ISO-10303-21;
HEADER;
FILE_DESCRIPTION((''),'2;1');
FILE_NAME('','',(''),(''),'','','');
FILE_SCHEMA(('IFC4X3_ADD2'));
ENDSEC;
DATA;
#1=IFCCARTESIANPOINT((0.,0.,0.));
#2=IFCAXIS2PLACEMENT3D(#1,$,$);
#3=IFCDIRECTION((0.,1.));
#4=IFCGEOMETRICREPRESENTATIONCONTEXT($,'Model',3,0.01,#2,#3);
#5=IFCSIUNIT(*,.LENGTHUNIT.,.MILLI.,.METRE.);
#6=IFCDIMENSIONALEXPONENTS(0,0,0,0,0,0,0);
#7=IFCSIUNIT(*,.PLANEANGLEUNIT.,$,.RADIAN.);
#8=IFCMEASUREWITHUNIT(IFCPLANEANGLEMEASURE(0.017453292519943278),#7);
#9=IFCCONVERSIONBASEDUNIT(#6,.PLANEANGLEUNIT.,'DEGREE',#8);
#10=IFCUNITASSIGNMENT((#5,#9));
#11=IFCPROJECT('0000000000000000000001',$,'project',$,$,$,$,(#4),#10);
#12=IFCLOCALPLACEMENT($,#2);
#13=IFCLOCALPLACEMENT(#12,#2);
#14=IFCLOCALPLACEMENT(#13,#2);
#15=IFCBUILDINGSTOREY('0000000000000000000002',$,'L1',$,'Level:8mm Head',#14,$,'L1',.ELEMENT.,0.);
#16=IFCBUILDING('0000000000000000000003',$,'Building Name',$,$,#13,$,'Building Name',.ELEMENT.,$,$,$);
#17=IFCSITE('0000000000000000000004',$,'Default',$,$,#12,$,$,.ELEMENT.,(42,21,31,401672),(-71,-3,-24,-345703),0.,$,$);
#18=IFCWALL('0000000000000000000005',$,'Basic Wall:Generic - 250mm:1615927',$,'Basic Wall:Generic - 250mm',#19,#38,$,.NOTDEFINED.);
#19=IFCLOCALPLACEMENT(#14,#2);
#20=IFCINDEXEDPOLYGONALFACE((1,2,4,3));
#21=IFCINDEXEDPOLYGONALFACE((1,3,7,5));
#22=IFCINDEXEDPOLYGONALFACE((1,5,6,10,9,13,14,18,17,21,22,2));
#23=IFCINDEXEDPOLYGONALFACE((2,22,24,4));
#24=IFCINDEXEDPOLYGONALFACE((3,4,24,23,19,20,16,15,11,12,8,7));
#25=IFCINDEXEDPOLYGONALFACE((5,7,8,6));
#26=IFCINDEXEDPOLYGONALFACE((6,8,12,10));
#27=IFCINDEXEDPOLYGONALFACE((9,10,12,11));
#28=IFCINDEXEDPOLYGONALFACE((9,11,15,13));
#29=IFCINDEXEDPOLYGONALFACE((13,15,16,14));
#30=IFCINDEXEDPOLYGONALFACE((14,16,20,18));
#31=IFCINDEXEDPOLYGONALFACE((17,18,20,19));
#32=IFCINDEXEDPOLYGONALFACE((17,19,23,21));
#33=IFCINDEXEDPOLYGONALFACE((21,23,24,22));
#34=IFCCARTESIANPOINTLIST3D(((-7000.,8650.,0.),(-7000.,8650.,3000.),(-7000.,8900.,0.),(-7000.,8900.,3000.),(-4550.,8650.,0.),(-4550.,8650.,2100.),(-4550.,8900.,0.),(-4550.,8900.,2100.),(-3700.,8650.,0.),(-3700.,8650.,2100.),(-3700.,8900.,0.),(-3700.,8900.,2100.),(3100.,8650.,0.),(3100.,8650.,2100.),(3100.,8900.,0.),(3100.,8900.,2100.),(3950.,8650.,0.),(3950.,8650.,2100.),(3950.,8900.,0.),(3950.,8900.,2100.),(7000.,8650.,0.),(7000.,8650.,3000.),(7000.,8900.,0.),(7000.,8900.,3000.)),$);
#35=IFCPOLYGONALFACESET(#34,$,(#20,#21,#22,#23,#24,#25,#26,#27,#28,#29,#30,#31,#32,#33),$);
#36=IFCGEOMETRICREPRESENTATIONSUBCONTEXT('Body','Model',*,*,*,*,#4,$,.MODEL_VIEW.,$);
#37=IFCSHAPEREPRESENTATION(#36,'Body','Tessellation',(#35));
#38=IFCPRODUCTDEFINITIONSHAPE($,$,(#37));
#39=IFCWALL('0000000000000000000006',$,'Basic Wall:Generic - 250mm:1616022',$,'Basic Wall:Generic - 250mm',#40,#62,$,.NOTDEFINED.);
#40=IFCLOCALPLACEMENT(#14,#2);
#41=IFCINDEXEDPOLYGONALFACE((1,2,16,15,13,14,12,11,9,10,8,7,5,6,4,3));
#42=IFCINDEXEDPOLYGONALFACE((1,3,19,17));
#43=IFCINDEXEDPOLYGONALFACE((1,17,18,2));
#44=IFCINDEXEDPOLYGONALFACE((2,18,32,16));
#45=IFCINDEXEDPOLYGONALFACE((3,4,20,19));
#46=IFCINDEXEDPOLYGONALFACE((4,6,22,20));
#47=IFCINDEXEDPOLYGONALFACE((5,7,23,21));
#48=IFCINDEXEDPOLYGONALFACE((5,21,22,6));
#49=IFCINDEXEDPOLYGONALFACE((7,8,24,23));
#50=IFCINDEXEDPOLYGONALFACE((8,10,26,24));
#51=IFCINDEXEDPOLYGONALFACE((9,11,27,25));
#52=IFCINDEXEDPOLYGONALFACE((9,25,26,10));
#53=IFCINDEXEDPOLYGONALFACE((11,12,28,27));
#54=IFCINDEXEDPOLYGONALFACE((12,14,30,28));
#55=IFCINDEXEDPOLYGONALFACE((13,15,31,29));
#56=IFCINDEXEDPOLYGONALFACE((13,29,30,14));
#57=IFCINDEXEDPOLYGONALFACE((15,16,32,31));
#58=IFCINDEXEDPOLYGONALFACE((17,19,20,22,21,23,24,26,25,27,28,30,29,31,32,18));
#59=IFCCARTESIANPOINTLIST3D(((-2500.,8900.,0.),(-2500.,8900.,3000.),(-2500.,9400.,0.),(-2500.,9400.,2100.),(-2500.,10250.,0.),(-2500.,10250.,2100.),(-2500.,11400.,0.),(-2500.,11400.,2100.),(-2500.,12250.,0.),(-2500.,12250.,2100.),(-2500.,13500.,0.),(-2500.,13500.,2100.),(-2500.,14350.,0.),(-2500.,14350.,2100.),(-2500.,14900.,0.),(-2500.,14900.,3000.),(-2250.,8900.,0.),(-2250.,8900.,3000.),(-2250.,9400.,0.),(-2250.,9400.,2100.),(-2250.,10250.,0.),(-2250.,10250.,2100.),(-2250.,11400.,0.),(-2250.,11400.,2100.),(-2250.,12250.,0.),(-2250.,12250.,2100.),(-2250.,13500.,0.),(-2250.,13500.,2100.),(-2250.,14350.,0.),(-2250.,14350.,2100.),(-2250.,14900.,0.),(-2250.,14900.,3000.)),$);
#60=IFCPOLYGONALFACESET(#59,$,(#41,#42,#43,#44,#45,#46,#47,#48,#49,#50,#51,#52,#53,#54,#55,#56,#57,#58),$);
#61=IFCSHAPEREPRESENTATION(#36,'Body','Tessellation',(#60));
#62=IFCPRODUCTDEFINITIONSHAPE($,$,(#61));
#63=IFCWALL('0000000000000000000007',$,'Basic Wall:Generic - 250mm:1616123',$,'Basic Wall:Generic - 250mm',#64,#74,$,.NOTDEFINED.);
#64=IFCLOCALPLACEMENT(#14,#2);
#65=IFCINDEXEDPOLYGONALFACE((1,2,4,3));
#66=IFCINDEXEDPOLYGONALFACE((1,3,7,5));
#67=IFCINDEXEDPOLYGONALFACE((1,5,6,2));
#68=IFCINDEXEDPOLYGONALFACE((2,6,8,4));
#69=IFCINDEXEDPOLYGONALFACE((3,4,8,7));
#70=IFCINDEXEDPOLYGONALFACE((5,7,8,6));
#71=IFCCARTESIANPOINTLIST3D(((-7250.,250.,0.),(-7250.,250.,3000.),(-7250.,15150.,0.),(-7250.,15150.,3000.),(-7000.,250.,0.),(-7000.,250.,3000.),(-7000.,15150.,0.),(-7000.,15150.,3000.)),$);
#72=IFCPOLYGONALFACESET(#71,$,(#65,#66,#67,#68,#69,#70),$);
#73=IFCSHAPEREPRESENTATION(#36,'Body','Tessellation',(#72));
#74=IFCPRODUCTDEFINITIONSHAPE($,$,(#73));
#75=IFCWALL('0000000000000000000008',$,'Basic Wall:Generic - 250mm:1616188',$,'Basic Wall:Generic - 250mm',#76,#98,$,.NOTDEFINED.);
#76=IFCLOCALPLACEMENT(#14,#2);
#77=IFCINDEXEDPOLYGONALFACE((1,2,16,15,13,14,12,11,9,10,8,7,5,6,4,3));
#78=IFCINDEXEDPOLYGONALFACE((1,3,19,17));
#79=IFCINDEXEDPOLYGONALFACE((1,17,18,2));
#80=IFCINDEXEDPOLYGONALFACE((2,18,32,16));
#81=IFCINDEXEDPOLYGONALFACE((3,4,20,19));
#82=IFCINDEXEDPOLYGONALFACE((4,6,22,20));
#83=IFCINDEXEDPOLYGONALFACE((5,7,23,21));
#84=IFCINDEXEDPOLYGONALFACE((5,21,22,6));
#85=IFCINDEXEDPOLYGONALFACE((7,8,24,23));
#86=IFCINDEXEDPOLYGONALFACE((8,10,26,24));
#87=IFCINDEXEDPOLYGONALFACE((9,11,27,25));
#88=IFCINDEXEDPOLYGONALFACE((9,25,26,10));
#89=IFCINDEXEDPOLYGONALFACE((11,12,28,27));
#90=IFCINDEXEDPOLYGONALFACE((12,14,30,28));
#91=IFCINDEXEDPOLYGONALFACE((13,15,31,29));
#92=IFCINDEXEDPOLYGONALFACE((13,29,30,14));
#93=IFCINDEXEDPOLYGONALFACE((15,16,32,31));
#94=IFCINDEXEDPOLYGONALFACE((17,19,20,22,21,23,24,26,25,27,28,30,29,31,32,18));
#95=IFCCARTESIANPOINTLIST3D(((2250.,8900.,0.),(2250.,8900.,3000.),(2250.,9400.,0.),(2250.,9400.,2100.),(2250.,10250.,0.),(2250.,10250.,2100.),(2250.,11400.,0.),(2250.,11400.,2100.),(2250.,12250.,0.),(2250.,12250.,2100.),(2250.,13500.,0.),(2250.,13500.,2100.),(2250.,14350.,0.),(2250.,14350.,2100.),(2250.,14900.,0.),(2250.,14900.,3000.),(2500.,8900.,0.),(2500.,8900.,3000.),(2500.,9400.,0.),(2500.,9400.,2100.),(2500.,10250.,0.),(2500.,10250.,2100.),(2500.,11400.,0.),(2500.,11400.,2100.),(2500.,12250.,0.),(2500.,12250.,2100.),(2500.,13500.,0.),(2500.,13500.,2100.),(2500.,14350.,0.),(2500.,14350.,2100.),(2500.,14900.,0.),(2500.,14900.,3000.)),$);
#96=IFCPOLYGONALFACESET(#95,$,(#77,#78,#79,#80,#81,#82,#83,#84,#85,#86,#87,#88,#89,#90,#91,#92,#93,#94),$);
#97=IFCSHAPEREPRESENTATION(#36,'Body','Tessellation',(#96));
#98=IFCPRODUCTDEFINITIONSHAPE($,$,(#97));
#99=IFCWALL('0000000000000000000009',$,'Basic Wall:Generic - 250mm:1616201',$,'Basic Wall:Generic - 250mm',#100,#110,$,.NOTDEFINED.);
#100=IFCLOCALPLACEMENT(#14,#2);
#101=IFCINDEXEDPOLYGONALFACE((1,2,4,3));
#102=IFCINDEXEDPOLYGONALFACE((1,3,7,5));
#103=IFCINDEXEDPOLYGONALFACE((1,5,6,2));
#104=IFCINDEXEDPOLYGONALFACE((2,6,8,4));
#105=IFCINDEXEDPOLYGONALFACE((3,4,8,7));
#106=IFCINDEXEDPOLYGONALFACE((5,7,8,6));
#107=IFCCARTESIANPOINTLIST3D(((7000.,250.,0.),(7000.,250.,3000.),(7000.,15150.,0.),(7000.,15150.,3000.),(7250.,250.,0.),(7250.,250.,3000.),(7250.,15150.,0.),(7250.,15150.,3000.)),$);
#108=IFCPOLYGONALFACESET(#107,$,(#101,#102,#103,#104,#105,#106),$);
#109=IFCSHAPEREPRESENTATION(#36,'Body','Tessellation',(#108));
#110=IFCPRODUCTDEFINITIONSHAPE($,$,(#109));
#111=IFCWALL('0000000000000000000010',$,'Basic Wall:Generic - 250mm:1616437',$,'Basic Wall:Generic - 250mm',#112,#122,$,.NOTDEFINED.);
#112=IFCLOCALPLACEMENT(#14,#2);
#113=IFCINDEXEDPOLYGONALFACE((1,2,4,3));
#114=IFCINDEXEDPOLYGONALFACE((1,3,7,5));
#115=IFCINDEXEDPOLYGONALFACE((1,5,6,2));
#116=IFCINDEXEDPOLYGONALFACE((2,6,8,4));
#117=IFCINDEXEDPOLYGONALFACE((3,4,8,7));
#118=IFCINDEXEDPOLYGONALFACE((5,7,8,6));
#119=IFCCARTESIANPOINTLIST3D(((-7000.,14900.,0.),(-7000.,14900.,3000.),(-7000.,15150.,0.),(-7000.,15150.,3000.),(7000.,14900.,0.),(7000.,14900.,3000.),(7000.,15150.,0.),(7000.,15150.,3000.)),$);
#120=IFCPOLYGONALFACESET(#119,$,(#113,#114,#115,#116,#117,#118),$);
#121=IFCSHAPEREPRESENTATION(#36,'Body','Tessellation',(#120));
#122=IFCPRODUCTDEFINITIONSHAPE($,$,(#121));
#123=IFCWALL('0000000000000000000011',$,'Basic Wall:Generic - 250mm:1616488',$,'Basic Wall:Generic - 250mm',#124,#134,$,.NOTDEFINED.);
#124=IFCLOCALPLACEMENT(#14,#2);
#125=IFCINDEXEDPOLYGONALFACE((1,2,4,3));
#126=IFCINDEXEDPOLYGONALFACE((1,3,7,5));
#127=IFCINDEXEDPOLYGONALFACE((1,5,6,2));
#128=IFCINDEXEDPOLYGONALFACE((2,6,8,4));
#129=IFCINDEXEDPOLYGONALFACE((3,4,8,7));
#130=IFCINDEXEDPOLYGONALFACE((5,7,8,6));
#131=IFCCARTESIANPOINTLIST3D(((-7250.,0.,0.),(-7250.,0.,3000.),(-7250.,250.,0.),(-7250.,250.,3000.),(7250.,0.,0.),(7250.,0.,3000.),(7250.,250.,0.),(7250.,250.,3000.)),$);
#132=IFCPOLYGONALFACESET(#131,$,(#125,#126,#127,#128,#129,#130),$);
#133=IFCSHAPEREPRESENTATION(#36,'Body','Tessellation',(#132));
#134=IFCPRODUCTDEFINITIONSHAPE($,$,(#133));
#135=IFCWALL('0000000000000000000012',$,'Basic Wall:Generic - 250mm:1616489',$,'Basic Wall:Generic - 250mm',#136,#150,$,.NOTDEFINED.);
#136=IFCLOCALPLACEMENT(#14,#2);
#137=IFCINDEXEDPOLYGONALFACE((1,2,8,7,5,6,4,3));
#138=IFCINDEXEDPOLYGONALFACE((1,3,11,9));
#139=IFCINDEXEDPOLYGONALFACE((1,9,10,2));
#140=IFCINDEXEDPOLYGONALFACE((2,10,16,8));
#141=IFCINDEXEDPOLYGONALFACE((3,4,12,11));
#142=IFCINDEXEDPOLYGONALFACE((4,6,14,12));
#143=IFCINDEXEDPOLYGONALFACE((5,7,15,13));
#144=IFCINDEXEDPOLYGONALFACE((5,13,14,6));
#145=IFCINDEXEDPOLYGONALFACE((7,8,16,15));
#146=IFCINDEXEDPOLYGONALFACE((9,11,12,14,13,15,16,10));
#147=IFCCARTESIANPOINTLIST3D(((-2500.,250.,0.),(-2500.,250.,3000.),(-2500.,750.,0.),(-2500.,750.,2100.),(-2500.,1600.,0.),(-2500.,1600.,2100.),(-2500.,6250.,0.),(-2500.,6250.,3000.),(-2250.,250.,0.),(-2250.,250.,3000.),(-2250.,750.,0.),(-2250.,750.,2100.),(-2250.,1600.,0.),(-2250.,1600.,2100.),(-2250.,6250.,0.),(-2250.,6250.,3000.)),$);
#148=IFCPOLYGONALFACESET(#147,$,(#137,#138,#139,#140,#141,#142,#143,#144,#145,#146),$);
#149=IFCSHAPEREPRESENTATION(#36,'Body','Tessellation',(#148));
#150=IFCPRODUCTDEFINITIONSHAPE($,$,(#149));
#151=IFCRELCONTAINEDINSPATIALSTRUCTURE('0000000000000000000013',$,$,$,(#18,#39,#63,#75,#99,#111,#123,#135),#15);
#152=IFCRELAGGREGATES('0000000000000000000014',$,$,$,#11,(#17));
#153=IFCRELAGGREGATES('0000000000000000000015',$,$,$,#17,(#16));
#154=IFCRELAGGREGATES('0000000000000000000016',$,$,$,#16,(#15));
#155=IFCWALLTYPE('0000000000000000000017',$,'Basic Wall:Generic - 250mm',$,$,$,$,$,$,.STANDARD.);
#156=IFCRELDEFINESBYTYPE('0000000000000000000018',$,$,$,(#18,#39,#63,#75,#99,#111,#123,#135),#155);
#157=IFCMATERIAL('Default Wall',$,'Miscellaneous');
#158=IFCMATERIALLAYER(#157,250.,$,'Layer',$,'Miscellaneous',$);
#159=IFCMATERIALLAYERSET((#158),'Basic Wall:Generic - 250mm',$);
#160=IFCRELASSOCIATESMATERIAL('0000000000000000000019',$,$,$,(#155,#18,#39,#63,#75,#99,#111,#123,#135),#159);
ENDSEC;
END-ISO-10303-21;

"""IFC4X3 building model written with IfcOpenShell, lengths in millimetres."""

from ifc_helpers import new_model, entity, si_unit, converted_unit, direction, frame, frame_2d, origin, place, context, subcontext, project, spatial, rectangle, extrude, material, layer, layer_set, type_object, element, save


model = new_model("IFC4X3")

# Units and contexts
model_context = context("Model", 3, precision=0.01, world=origin(), true_north=direction((0.0, 1.0)))
body_context = subcontext(model_context, "Body", "Model", "MODEL_VIEW")
ifc_project = project(units=[si_unit("LENGTHUNIT", "METRE", prefix="MILLI"), converted_unit("PLANEANGLEUNIT", "DEGREE", entity("IfcPlaneAngleMeasure", 0.017453292519943278), si_unit("PLANEANGLEUNIT", "RADIAN"), dimensions=[0, 0, 0, 0, 0, 0, 0])], contexts=[model_context])

# Site, building, storey
site_placement = place(None, origin())
site = spatial("IfcSite", under=ifc_project, at=site_placement, Name="Default", CompositionType="ELEMENT", RefLatitude=(42, 21, 31, 401672), RefLongitude=(-71, -3, -24, -345703), RefElevation=0.0)
building_placement = place(site_placement, origin())
building = spatial("IfcBuilding", under=site, at=building_placement, Name="Building Name", LongName="Building Name", CompositionType="ELEMENT")
storey_placement = place(building_placement, origin())
storey = spatial("IfcBuildingStorey", under=building, at=storey_placement, Name="L1", ObjectType="Level:8mm Head", LongName="L1", CompositionType="ELEMENT", Elevation=0.0)

# Walls, openings
ifc_material = material(Name="Default Wall", Category="Miscellaneous")
ifc_layer_1 = layer(ifc_material, 250.0, Name="Layer", Category="Miscellaneous")
ifc_layer_set_1 = layer_set([ifc_layer_1], Name="Basic Wall:Generic - 250mm")
wall_type_1 = type_object("IfcWallType", Name="Basic Wall:Generic - 250mm", PredefinedType="STANDARD", material=ifc_layer_set_1)
wall_1_placement = place(storey_placement, frame((-7000.0, 8775.0, 0.0)))
wall_1 = element("IfcWall", 1, at=wall_1_placement, inside=storey, type_object=wall_type_1, material=ifc_layer_set_1, Name="Basic Wall:Generic - 250mm:1615927", ObjectType="Basic Wall:Generic - 250mm", PredefinedType="NOTDEFINED", context=body_context, shape_type="SweptSolid", body=[
    extrude(rectangle(XDim=14000.0, YDim=250.0, at=frame_2d((7000.0, 0.0), x_axis=(1.0, 0.0))), origin(), (0.0, 0.0, 1.0), 3000.0),
])
opening_1_placement = place(wall_1_placement, frame((2450.0, -125.0, 0.0)))
element("IfcOpeningElement", 2, at=opening_1_placement, cuts=wall_1, PredefinedType="OPENING", context=body_context, shape_type="SweptSolid", body=[
    extrude(rectangle(XDim=2100.0, YDim=850.0, at=frame_2d((1050.0, 425.0), x_axis=(1.0, 0.0))), frame((0.0, 0.0, 0.0), z_axis=(0.0, 1.0, 0.0), x_axis=(0.0, 0.0, 1.0)), (0.0, 0.0, 1.0), 250.0),
])
opening_2_placement = place(wall_1_placement, frame((10100.0, -125.0, 0.0)))
element("IfcOpeningElement", 3, at=opening_2_placement, cuts=wall_1, PredefinedType="OPENING", context=body_context, shape_type="SweptSolid", body=[
    extrude(rectangle(XDim=2100.0, YDim=850.0, at=frame_2d((1050.0, 425.0), x_axis=(1.0, 0.0))), frame((0.0, 0.0, 0.0), z_axis=(0.0, 1.0, 0.0), x_axis=(0.0, 0.0, 1.0)), (0.0, 0.0, 1.0), 250.0),
])
wall_2_placement = place(storey_placement, frame((-2375.0, 8900.0, 0.0), z_axis=(0.0, 0.0, 1.0), x_axis=(0.0, 1.0, 0.0)))
wall_2 = element("IfcWall", 4, at=wall_2_placement, inside=storey, type_object=wall_type_1, material=ifc_layer_set_1, Name="Basic Wall:Generic - 250mm:1616022", ObjectType="Basic Wall:Generic - 250mm", PredefinedType="NOTDEFINED", context=body_context, shape_type="SweptSolid", body=[
    extrude(rectangle(XDim=6000.0, YDim=250.0, at=frame_2d((3000.0, 0.0), x_axis=(1.0, 0.0))), origin(), (0.0, 0.0, 1.0), 3000.0),
])
opening_3_placement = place(wall_2_placement, frame((1350.0, 125.0, 0.0)))
element("IfcOpeningElement", 5, at=opening_3_placement, cuts=wall_2, PredefinedType="OPENING", context=body_context, shape_type="SweptSolid", body=[
    extrude(rectangle(XDim=2100.0, YDim=850.0, at=frame_2d((1050.0, 425.0), x_axis=(1.0, 0.0))), frame((0.0, 0.0, 0.0), z_axis=(0.0, -1.0, 0.0), x_axis=(0.0, 0.0, 1.0)), (0.0, 0.0, 1.0), 250.0),
])
opening_4_placement = place(wall_2_placement, frame((3350.0, 125.0, 0.0)))
element("IfcOpeningElement", 6, at=opening_4_placement, cuts=wall_2, PredefinedType="OPENING", context=body_context, shape_type="SweptSolid", body=[
    extrude(rectangle(XDim=2100.0, YDim=850.0, at=frame_2d((1050.0, 425.0), x_axis=(1.0, 0.0))), frame((0.0, 0.0, 0.0), z_axis=(0.0, -1.0, 0.0), x_axis=(0.0, 0.0, 1.0)), (0.0, 0.0, 1.0), 250.0),
])
opening_5_placement = place(wall_2_placement, frame((5450.0, 125.0, 0.0)))
element("IfcOpeningElement", 7, at=opening_5_placement, cuts=wall_2, PredefinedType="OPENING", context=body_context, shape_type="SweptSolid", body=[
    extrude(rectangle(XDim=2100.0, YDim=850.0, at=frame_2d((1050.0, 425.0), x_axis=(1.0, 0.0))), frame((0.0, 0.0, 0.0), z_axis=(0.0, -1.0, 0.0), x_axis=(0.0, 0.0, 1.0)), (0.0, 0.0, 1.0), 250.0),
])

# Wall
wall_3_placement = place(storey_placement, frame((-7125.0, 15150.0, 0.0), z_axis=(0.0, 0.0, 1.0), x_axis=(0.0, -1.0, 0.0)))
element("IfcWall", 8, at=wall_3_placement, inside=storey, type_object=wall_type_1, material=ifc_layer_set_1, Name="Basic Wall:Generic - 250mm:1616123", ObjectType="Basic Wall:Generic - 250mm", PredefinedType="NOTDEFINED", context=body_context, shape_type="SweptSolid", body=[
    extrude(rectangle(XDim=14900.0, YDim=250.0, at=frame_2d((7450.0, 0.0), x_axis=(-1.0, 0.0))), origin(), (0.0, 0.0, 1.0), 3000.0),
])

# Wall, openings
wall_4_placement = place(storey_placement, frame((2375.0, 8900.0, 0.0), z_axis=(0.0, 0.0, 1.0), x_axis=(0.0, 1.0, 0.0)))
wall_4 = element("IfcWall", 9, at=wall_4_placement, inside=storey, type_object=wall_type_1, material=ifc_layer_set_1, Name="Basic Wall:Generic - 250mm:1616188", ObjectType="Basic Wall:Generic - 250mm", PredefinedType="NOTDEFINED", context=body_context, shape_type="SweptSolid", body=[
    extrude(rectangle(XDim=6000.0, YDim=250.0, at=frame_2d((3000.0, 0.0), x_axis=(-1.0, 0.0))), origin(), (0.0, 0.0, 1.0), 3000.0),
])
opening_6_placement = place(wall_4_placement, frame((500.0, -125.0, 0.0)))
element("IfcOpeningElement", 10, at=opening_6_placement, cuts=wall_4, PredefinedType="OPENING", context=body_context, shape_type="SweptSolid", body=[
    extrude(rectangle(XDim=2100.0, YDim=850.0, at=frame_2d((1050.0, 425.0), x_axis=(1.0, 0.0))), frame((0.0, 0.0, 0.0), z_axis=(0.0, 1.0, 0.0), x_axis=(0.0, 0.0, 1.0)), (0.0, 0.0, 1.0), 250.0),
])
opening_7_placement = place(wall_4_placement, frame((2500.0, -125.0, 0.0)))
element("IfcOpeningElement", 11, at=opening_7_placement, cuts=wall_4, PredefinedType="OPENING", context=body_context, shape_type="SweptSolid", body=[
    extrude(rectangle(XDim=2100.0, YDim=850.0, at=frame_2d((1050.0, 425.0), x_axis=(1.0, 0.0))), frame((0.0, 0.0, 0.0), z_axis=(0.0, 1.0, 0.0), x_axis=(0.0, 0.0, 1.0)), (0.0, 0.0, 1.0), 250.0),
])
opening_8_placement = place(wall_4_placement, frame((4600.0, -125.0, 0.0)))
element("IfcOpeningElement", 12, at=opening_8_placement, cuts=wall_4, PredefinedType="OPENING", context=body_context, shape_type="SweptSolid", body=[
    extrude(rectangle(XDim=2100.0, YDim=850.0, at=frame_2d((1050.0, 425.0), x_axis=(1.0, 0.0))), frame((0.0, 0.0, 0.0), z_axis=(0.0, 1.0, 0.0), x_axis=(0.0, 0.0, 1.0)), (0.0, 0.0, 1.0), 250.0),
])

# Walls
wall_5_placement = place(storey_placement, frame((7125.0, 250.0, 0.0), z_axis=(0.0, 0.0, 1.0), x_axis=(0.0, 1.0, 0.0)))
element("IfcWall", 13, at=wall_5_placement, inside=storey, type_object=wall_type_1, material=ifc_layer_set_1, Name="Basic Wall:Generic - 250mm:1616201", ObjectType="Basic Wall:Generic - 250mm", PredefinedType="NOTDEFINED", context=body_context, shape_type="SweptSolid", body=[
    extrude(rectangle(XDim=14900.0, YDim=250.0, at=frame_2d((7450.0, 0.0), x_axis=(-1.0, 0.0))), origin(), (0.0, 0.0, 1.0), 3000.0),
])
wall_6_placement = place(storey_placement, frame((-7000.0, 15025.0, 0.0)))
element("IfcWall", 14, at=wall_6_placement, inside=storey, type_object=wall_type_1, material=ifc_layer_set_1, Name="Basic Wall:Generic - 250mm:1616437", ObjectType="Basic Wall:Generic - 250mm", PredefinedType="NOTDEFINED", context=body_context, shape_type="SweptSolid", body=[
    extrude(rectangle(XDim=14000.0, YDim=250.0, at=frame_2d((7000.0, 0.0), x_axis=(-1.0, 0.0))), origin(), (0.0, 0.0, 1.0), 3000.0),
])
wall_7_placement = place(storey_placement, frame((-7250.0, 125.0, 0.0)))
element("IfcWall", 15, at=wall_7_placement, inside=storey, type_object=wall_type_1, material=ifc_layer_set_1, Name="Basic Wall:Generic - 250mm:1616488", ObjectType="Basic Wall:Generic - 250mm", PredefinedType="NOTDEFINED", context=body_context, shape_type="SweptSolid", body=[
    extrude(rectangle(XDim=14500.0, YDim=250.0, at=frame_2d((7250.0, 0.0), x_axis=(-1.0, 0.0))), origin(), (0.0, 0.0, 1.0), 3000.0),
])

# Wall, opening
wall_8_placement = place(storey_placement, frame((-2375.0, 250.0, 0.0), z_axis=(0.0, 0.0, 1.0), x_axis=(0.0, 1.0, 0.0)))
wall_8 = element("IfcWall", 16, at=wall_8_placement, inside=storey, type_object=wall_type_1, material=ifc_layer_set_1, Name="Basic Wall:Generic - 250mm:1616489", ObjectType="Basic Wall:Generic - 250mm", PredefinedType="NOTDEFINED", context=body_context, shape_type="SweptSolid", body=[
    extrude(rectangle(XDim=6000.0, YDim=250.0, at=frame_2d((3000.0, 0.0), x_axis=(1.0, 0.0))), origin(), (0.0, 0.0, 1.0), 3000.0),
])
opening_9_placement = place(wall_8_placement, frame((1350.0, 125.0, 0.0)))
element("IfcOpeningElement", 17, at=opening_9_placement, cuts=wall_8, PredefinedType="OPENING", context=body_context, shape_type="SweptSolid", body=[
    extrude(rectangle(XDim=2100.0, YDim=850.0, at=frame_2d((1050.0, 425.0), x_axis=(1.0, 0.0))), frame((0.0, 0.0, 0.0), z_axis=(0.0, -1.0, 0.0), x_axis=(0.0, 0.0, 1.0)), (0.0, 0.0, 1.0), 250.0),
])

save(model, "model.ifc")
